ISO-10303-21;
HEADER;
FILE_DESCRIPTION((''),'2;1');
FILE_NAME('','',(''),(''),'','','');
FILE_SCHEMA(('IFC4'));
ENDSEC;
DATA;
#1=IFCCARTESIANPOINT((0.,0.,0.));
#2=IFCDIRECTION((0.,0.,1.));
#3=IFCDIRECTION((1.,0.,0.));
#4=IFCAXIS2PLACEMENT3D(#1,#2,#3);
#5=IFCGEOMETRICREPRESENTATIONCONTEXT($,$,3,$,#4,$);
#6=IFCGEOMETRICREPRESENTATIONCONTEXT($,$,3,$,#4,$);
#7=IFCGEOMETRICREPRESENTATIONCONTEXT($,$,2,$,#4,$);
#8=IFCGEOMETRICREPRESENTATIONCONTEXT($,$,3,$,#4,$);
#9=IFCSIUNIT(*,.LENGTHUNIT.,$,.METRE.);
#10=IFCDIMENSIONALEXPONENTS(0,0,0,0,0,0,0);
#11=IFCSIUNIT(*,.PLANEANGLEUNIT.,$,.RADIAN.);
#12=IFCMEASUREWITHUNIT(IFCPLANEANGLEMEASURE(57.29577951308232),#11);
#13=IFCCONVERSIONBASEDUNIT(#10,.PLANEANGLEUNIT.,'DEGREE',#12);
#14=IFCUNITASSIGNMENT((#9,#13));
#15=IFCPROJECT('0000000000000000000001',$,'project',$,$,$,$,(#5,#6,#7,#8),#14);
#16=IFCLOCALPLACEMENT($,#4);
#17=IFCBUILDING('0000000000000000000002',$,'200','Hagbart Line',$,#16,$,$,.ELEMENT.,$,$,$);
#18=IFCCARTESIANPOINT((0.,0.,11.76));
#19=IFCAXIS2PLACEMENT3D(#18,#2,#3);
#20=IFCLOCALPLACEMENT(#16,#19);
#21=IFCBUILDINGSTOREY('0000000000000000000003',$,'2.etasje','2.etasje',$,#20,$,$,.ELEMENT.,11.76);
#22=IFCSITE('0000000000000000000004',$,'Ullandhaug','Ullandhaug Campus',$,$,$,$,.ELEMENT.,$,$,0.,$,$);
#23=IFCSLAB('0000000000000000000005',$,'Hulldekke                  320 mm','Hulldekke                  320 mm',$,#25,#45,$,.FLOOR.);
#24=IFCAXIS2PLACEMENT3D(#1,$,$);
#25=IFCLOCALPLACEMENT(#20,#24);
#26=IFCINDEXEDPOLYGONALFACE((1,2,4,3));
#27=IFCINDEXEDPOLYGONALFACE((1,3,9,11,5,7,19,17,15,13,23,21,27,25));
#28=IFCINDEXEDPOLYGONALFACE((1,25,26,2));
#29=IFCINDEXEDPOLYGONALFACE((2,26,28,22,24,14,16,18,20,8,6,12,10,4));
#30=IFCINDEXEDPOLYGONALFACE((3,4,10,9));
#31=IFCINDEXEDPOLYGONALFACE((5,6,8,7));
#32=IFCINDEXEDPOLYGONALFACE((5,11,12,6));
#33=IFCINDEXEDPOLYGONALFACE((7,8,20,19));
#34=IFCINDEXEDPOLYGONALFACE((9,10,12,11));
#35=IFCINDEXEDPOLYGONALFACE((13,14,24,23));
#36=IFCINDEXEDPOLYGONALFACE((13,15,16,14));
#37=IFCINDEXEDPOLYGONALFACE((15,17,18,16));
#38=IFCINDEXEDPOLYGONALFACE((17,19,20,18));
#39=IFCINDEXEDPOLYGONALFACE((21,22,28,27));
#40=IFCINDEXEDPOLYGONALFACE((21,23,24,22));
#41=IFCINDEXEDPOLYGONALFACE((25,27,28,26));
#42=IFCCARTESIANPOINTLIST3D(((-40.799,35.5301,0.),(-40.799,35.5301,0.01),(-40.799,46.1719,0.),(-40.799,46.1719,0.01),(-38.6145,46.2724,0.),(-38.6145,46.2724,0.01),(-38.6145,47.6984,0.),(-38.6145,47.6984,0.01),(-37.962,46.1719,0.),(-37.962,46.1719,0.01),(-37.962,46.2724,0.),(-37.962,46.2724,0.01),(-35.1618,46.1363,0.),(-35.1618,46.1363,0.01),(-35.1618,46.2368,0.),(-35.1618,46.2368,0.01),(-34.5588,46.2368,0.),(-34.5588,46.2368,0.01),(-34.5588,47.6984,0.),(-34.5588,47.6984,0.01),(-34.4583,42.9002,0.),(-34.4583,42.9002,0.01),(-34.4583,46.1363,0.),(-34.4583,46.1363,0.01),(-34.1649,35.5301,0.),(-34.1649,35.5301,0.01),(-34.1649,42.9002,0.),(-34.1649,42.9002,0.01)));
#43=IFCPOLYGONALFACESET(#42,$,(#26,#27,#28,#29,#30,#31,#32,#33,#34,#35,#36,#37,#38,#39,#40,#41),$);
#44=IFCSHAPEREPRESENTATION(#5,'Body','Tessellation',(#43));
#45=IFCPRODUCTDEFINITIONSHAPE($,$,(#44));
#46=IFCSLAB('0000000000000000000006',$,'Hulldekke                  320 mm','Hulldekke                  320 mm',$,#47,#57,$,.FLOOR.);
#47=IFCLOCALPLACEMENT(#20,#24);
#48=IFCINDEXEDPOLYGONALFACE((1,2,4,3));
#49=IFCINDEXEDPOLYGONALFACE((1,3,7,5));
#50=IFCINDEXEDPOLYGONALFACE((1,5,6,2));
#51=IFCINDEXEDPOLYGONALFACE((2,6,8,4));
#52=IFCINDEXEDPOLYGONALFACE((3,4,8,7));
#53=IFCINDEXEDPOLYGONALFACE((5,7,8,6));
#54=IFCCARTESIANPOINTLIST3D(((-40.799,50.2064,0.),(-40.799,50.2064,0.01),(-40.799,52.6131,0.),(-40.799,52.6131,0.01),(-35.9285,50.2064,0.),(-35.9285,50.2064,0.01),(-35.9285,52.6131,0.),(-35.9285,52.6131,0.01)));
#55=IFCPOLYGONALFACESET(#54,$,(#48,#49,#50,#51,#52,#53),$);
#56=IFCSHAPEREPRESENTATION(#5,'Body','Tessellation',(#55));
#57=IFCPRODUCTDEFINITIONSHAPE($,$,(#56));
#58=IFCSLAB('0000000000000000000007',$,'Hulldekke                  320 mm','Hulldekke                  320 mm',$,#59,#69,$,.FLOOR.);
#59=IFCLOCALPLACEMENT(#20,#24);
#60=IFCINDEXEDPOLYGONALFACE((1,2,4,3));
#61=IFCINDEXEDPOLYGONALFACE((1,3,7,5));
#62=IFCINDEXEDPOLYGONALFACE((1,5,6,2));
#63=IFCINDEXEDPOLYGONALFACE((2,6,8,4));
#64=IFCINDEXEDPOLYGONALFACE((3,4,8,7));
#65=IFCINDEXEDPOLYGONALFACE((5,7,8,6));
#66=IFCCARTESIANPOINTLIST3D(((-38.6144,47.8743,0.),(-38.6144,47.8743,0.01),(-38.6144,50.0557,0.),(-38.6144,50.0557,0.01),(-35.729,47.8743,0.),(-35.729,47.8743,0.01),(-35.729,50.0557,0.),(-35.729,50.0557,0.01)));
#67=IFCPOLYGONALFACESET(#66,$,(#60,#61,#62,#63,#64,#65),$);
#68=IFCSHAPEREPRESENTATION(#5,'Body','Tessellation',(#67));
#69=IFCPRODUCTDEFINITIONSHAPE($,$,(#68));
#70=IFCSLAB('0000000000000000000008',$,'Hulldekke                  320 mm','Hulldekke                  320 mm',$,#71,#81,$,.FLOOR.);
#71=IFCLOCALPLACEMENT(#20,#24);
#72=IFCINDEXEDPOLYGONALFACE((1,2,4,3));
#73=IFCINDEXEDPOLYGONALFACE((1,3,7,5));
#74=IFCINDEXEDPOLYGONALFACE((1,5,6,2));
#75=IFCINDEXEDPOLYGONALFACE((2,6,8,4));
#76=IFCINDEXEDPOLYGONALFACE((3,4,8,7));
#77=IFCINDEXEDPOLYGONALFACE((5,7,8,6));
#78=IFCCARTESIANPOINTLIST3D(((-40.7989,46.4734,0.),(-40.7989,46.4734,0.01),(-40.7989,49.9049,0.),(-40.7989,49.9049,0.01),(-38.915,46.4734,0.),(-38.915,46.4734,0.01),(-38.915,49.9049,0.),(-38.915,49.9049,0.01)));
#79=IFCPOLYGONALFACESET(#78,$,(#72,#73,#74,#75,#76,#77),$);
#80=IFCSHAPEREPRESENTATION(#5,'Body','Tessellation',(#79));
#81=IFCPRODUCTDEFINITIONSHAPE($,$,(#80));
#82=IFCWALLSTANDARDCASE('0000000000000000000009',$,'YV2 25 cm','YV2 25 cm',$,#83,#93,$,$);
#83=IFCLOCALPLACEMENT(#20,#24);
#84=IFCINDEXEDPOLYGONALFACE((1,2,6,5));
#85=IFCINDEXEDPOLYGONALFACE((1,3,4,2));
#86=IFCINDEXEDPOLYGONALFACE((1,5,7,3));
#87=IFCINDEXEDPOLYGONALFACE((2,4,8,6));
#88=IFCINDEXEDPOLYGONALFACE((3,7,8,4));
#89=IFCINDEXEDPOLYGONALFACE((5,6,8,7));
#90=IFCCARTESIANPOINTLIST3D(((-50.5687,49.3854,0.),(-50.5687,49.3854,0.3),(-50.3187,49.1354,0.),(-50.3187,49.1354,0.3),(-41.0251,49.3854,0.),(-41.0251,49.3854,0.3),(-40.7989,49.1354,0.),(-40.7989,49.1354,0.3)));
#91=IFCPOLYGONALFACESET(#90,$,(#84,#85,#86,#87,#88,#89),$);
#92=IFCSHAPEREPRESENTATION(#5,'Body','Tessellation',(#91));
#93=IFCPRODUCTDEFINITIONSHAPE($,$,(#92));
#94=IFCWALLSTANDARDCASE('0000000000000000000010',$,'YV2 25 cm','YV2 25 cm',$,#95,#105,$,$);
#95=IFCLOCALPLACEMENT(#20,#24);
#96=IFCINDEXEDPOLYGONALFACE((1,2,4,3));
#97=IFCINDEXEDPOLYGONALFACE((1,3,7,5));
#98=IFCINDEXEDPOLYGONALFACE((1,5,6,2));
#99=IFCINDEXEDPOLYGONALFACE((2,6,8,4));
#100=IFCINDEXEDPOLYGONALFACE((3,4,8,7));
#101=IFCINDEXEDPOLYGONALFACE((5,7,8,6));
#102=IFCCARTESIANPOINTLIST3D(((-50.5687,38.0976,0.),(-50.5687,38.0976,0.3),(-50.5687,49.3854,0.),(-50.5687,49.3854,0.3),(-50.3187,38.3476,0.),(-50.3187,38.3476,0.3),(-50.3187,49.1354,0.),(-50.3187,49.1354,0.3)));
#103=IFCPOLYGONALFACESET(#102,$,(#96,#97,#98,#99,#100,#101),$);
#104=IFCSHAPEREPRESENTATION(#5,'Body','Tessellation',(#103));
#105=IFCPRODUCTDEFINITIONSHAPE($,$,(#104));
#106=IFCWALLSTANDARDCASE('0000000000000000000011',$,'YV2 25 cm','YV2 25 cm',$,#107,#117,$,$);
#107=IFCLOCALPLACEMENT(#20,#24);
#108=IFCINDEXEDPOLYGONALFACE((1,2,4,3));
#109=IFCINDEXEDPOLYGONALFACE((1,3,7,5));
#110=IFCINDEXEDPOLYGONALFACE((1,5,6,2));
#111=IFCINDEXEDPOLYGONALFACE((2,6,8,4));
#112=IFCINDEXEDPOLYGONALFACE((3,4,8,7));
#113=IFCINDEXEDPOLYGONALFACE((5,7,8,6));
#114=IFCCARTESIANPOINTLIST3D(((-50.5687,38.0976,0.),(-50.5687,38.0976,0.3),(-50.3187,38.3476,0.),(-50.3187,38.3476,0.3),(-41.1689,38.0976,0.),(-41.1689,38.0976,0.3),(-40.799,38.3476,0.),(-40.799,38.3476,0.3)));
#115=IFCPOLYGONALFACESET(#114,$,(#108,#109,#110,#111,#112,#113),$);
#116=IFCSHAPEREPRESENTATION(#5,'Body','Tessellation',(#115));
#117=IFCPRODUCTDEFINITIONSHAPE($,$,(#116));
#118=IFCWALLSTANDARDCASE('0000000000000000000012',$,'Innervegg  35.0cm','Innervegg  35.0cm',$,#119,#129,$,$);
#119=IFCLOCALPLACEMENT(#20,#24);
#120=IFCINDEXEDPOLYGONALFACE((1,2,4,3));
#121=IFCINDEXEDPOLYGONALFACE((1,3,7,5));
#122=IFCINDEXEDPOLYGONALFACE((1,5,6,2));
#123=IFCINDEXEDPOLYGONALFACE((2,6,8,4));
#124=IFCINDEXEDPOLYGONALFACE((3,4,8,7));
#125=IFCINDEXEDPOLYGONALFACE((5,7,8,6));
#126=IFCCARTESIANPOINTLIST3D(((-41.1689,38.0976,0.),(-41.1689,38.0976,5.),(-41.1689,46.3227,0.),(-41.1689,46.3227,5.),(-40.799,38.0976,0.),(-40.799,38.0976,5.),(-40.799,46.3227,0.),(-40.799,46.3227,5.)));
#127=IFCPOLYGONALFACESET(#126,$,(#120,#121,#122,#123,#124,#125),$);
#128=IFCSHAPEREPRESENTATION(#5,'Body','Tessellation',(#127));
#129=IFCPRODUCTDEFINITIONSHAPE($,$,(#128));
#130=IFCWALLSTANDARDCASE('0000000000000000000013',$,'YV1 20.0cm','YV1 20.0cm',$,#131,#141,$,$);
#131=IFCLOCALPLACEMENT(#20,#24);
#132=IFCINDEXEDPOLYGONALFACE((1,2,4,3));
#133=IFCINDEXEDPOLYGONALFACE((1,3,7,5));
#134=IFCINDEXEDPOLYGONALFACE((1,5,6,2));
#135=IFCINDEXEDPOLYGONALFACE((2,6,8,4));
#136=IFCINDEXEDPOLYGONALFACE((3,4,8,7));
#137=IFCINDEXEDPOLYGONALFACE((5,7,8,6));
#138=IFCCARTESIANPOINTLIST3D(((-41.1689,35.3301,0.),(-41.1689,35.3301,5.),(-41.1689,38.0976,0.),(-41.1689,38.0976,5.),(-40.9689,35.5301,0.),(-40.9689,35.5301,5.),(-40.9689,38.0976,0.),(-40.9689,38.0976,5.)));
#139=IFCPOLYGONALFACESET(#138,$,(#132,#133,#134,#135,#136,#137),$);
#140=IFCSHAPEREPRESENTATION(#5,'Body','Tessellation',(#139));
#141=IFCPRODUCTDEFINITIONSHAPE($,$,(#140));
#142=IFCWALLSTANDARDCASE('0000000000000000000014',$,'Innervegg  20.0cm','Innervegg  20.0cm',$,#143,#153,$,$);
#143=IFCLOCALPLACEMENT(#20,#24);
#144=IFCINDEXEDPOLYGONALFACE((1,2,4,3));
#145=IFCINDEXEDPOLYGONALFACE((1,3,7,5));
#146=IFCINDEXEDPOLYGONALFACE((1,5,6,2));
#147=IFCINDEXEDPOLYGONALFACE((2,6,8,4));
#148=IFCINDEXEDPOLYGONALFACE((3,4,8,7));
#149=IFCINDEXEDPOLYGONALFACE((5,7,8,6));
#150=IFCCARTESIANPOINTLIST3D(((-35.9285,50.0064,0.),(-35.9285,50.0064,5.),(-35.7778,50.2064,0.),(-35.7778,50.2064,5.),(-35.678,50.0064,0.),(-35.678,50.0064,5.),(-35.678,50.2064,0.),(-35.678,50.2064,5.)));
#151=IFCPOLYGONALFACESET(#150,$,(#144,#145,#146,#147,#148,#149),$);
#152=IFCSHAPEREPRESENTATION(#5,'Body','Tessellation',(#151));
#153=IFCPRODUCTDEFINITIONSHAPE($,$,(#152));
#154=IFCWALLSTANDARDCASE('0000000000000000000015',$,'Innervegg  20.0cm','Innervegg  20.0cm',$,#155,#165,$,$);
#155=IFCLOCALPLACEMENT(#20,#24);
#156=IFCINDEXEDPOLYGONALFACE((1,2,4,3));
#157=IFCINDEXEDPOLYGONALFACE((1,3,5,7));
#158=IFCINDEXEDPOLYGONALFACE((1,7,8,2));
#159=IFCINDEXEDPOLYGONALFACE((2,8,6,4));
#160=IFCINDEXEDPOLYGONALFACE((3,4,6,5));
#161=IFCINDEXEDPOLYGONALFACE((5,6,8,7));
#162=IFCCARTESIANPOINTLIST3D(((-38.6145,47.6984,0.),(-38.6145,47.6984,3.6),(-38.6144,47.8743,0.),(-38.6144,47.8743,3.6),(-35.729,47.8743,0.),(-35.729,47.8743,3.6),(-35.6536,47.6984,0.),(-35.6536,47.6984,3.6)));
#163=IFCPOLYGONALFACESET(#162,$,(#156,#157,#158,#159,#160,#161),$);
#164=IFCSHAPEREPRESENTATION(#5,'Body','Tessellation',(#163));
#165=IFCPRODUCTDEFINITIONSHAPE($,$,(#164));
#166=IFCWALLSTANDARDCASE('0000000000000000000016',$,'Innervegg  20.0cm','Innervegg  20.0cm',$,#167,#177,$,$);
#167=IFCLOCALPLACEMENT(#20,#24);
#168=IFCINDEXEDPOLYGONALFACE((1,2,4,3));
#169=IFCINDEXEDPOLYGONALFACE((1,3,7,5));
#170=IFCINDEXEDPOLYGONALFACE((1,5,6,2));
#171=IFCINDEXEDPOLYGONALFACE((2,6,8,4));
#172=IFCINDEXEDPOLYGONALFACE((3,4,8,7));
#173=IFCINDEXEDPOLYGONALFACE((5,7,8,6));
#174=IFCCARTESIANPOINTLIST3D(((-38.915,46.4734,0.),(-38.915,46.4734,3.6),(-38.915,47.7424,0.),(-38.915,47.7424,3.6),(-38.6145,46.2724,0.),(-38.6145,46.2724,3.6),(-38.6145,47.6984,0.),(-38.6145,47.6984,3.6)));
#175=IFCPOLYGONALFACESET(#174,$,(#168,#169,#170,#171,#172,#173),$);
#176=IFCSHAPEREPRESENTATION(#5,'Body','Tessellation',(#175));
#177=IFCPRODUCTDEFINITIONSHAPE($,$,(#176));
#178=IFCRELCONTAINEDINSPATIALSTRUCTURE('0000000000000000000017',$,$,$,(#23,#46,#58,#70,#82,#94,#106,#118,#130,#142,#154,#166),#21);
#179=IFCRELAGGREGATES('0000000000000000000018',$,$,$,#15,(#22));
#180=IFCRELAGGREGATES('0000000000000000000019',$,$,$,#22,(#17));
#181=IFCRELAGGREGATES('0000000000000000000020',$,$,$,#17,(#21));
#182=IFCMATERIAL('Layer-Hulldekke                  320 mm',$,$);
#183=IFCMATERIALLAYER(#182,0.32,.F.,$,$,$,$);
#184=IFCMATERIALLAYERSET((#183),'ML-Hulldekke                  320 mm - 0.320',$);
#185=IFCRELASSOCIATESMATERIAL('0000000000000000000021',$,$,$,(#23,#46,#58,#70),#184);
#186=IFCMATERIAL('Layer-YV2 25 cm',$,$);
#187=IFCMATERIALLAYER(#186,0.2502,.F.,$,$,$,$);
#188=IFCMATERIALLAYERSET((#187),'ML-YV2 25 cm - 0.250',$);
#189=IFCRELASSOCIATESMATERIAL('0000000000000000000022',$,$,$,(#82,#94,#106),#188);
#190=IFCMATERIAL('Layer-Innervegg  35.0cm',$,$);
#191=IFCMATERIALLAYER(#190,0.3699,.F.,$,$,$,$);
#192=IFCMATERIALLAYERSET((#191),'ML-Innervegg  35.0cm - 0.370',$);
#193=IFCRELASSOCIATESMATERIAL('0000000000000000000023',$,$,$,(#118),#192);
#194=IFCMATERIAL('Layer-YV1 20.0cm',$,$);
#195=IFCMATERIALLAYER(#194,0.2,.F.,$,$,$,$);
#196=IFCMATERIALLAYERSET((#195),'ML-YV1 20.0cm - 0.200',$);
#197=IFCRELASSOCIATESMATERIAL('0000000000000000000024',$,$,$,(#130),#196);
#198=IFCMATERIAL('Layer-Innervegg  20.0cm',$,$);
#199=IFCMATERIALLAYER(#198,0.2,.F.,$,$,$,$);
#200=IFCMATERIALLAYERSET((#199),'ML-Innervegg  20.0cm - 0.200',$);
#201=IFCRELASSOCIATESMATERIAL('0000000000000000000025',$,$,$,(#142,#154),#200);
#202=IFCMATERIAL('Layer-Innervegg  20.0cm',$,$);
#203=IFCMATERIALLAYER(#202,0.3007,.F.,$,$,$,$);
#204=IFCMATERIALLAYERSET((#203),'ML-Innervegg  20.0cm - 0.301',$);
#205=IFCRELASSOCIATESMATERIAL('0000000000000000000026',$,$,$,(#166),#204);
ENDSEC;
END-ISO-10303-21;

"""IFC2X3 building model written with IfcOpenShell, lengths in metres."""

from ifc_helpers import new_model, entity, si_unit, converted_unit, frame, origin_with_axes, place, context, project, spatial, polyline, outline, extrude, material, layer, layer_set, layer_usage, element, save


model = new_model("IFC2X3")

# Units and contexts
context_of_model_1 = context(None, 3, world=origin_with_axes())
context_of_model_2 = context(None, 3, world=origin_with_axes())
context_of_model_3 = context(None, 2, world=origin_with_axes())
context_of_model_4 = context(None, 3, world=origin_with_axes())
ifc_project = project(units=[si_unit("LENGTHUNIT", "METRE"), converted_unit("PLANEANGLEUNIT", "DEGREE", entity("IfcPlaneAngleMeasure", 57.29577951308232), si_unit("PLANEANGLEUNIT", "RADIAN"), dimensions=[0, 0, 0, 0, 0, 0, 0])], contexts=[context_of_model_1, context_of_model_2, context_of_model_3, context_of_model_4])

# Site, building, storey
site = spatial("IfcSite", under=ifc_project, Name="Ullandhaug", Description="Ullandhaug Campus", CompositionType="ELEMENT", RefElevation=0.0)
building_placement = place(None, origin_with_axes())
building = spatial("IfcBuilding", under=site, at=building_placement, Name="200", Description="Hagbart Line", CompositionType="ELEMENT")
storey_placement = place(building_placement, frame((0.0, 0.0, 11.76), z_axis=(0.0, 0.0, 1.0), x_axis=(1.0, 0.0, 0.0)))
storey = spatial("IfcBuildingStorey", under=building, at=storey_placement, Name="2.etasje", Description="2.etasje", CompositionType="ELEMENT", Elevation=11.76)

# Slabs
ifc_material_1 = material(Name="Layer-Hulldekke                  320 mm")
ifc_layer_1 = layer(ifc_material_1, 0.32, ventilated=False)
ifc_layer_set_1 = layer_set([ifc_layer_1], Name="ML-Hulldekke                  320 mm - 0.320")
ifc_layer_usage_1 = layer_usage(ifc_layer_set_1, "AXIS2", "POSITIVE", 0.0)
slab_1_placement = place(storey_placement, frame((-40.799, 35.5301, 0.0), z_axis=(0.0, 0.0, 1.0), x_axis=(1.0, 0.0, 0.0)))
element("IfcSlab", 1, at=slab_1_placement, inside=storey, material=ifc_layer_usage_1, Name="Hulldekke                  320 mm", Description="Hulldekke                  320 mm", PredefinedType="FLOOR", context=context_of_model_1, shape_type="SweptSolid", body=[
    extrude(outline(polyline([(0.0, 0.0), (6.6341, 0.0), (6.6341, 7.37), (6.3407, 7.37), (6.3407, 10.6061), (5.6371, 10.6061), (5.6371, 10.7066), (6.2402, 10.7066), (6.2402, 12.1683), (2.1845, 12.1683), (2.1845, 10.7423), (2.837, 10.7423), (2.837, 10.6418), (0.0, 10.6418), (0.0, 0.0)])), origin_with_axes(), (0.0, 0.0, 1.0), 0.01),
])
slab_2_placement = place(storey_placement, frame((-40.799, 50.2064, 0.0), z_axis=(0.0, 0.0, 1.0), x_axis=(1.0, 0.0, 0.0)))
element("IfcSlab", 2, at=slab_2_placement, inside=storey, material=ifc_layer_usage_1, Name="Hulldekke                  320 mm", Description="Hulldekke                  320 mm", PredefinedType="FLOOR", context=context_of_model_1, shape_type="SweptSolid", body=[
    extrude(outline(polyline([(0.0, 0.0), (4.8704, 0.0), (4.8704, 2.4066), (0.0, 2.4066), (0.0, 0.0)])), origin_with_axes(), (0.0, 0.0, 1.0), 0.01),
])
slab_3_placement = place(storey_placement, frame((-38.6144, 47.8743, 0.0), z_axis=(0.0, 0.0, 1.0), x_axis=(1.0, 0.0, 0.0)))
element("IfcSlab", 3, at=slab_3_placement, inside=storey, material=ifc_layer_usage_1, Name="Hulldekke                  320 mm", Description="Hulldekke                  320 mm", PredefinedType="FLOOR", context=context_of_model_1, shape_type="SweptSolid", body=[
    extrude(outline(polyline([(0.0, 0.0), (2.8854, 0.0), (2.8854, 2.1814), (0.0, 2.1814), (0.0, 0.0)])), origin_with_axes(), (0.0, 0.0, 1.0), 0.01),
])
slab_4_placement = place(storey_placement, frame((-40.7989, 46.4734, 0.0), z_axis=(0.0, 0.0, 1.0), x_axis=(1.0, 0.0, 0.0)))
element("IfcSlab", 4, at=slab_4_placement, inside=storey, material=ifc_layer_usage_1, Name="Hulldekke                  320 mm", Description="Hulldekke                  320 mm", PredefinedType="FLOOR", context=context_of_model_1, shape_type="SweptSolid", body=[
    extrude(outline(polyline([(0.0, 0.0), (1.8839, 0.0), (1.8839, 3.4315), (0.0, 3.4315), (0.0, 0.0)])), origin_with_axes(), (0.0, 0.0, 1.0), 0.01),
])

# Walls
ifc_material_2 = material(Name="Layer-YV2 25 cm")
ifc_layer_2 = layer(ifc_material_2, 0.2502, ventilated=False)
ifc_layer_set_2 = layer_set([ifc_layer_2], Name="ML-YV2 25 cm - 0.250")
ifc_layer_usage_2 = layer_usage(ifc_layer_set_2, "AXIS2", "POSITIVE", 0.0)
wall_1_placement = place(storey_placement, frame((-41.0251, 49.3854, 0.0), z_axis=(0.0, 0.0, 1.0), x_axis=(-1.0, 0.0, 0.0)))
element("IfcWallStandardCase", 5, at=wall_1_placement, inside=storey, material=ifc_layer_usage_2, Name="YV2 25 cm", Description="YV2 25 cm", context=context_of_model_1, shape_type="SweptSolid", body=[
    extrude(outline(polyline([(0.0, 0.0), (9.5436, 0.0), (9.2936, 0.25), (-0.2262, 0.25), (0.0, 0.0)])), frame((0.0, 0.0, 0.0), z_axis=(0.0, 0.0, 1.0), x_axis=(1.0, 0.0, 0.0)), (0.0, 0.0, 1.0), 0.3),
])
wall_2_placement = place(storey_placement, frame((-50.5687, 49.3854, 0.0), z_axis=(0.0, 0.0, 1.0), x_axis=(0.0, -1.0, 0.0)))
element("IfcWallStandardCase", 6, at=wall_2_placement, inside=storey, material=ifc_layer_usage_2, Name="YV2 25 cm", Description="YV2 25 cm", context=context_of_model_1, shape_type="SweptSolid", body=[
    extrude(outline(polyline([(0.0, 0.0), (11.2878, 0.0), (11.0378, 0.25), (0.25, 0.25), (0.0, 0.0)])), frame((0.0, 0.0, 0.0), z_axis=(0.0, 0.0, 1.0), x_axis=(1.0, 0.0, 0.0)), (0.0, 0.0, 1.0), 0.3),
])
wall_3_placement = place(storey_placement, frame((-50.5687, 38.0976, 0.0), z_axis=(0.0, 0.0, 1.0), x_axis=(1.0, 0.0, 0.0)))
element("IfcWallStandardCase", 7, at=wall_3_placement, inside=storey, material=ifc_layer_usage_2, Name="YV2 25 cm", Description="YV2 25 cm", context=context_of_model_1, shape_type="SweptSolid", body=[
    extrude(outline(polyline([(0.0, 0.0), (9.3999, 0.0), (9.7698, 0.25), (0.25, 0.25), (0.0, 0.0)])), origin_with_axes(), (0.0, 0.0, 1.0), 0.3),
])
ifc_material_3 = material(Name="Layer-Innervegg  35.0cm")
ifc_layer_3 = layer(ifc_material_3, 0.3699, ventilated=False)
ifc_layer_set_3 = layer_set([ifc_layer_3], Name="ML-Innervegg  35.0cm - 0.370")
ifc_layer_usage_3 = layer_usage(ifc_layer_set_3, "AXIS2", "POSITIVE", 0.0)
wall_4_placement = place(storey_placement, frame((-41.1689, 46.3227, 0.0), z_axis=(0.0, 0.0, 1.0), x_axis=(0.0, -1.0, 0.0)))
element("IfcWallStandardCase", 8, at=wall_4_placement, inside=storey, material=ifc_layer_usage_3, Name="Innervegg  35.0cm", Description="Innervegg  35.0cm", context=context_of_model_1, shape_type="SweptSolid", body=[
    extrude(outline(polyline([(0.0, 0.0), (8.225, 0.0), (8.225, 0.3699), (0.0, 0.3699), (0.0, 0.0)])), frame((0.0, 0.0, 0.0), z_axis=(0.0, 0.0, 1.0), x_axis=(1.0, 0.0, 0.0)), (0.0, 0.0, 1.0), 5.0),
])
ifc_material_4 = material(Name="Layer-YV1 20.0cm")
ifc_layer_4 = layer(ifc_material_4, 0.2, ventilated=False)
ifc_layer_set_4 = layer_set([ifc_layer_4], Name="ML-YV1 20.0cm - 0.200")
ifc_layer_usage_4 = layer_usage(ifc_layer_set_4, "AXIS2", "POSITIVE", 0.0)
wall_5_placement = place(storey_placement, frame((-41.1689, 38.0976, 0.0), z_axis=(0.0, 0.0, 1.0), x_axis=(0.0, -1.0, 0.0)))
element("IfcWallStandardCase", 9, at=wall_5_placement, inside=storey, material=ifc_layer_usage_4, Name="YV1 20.0cm", Description="YV1 20.0cm", context=context_of_model_1, shape_type="SweptSolid", body=[
    extrude(outline(polyline([(0.0, 0.0), (2.7675, 0.0), (2.5675, 0.2), (0.0, 0.2), (0.0, 0.0)])), frame((0.0, 0.0, 0.0), z_axis=(0.0, 0.0, 1.0), x_axis=(1.0, 0.0, 0.0)), (0.0, 0.0, 1.0), 5.0),
])
ifc_material_5 = material(Name="Layer-Innervegg  20.0cm")
ifc_layer_5 = layer(ifc_material_5, 0.2, ventilated=False)
ifc_layer_set_5 = layer_set([ifc_layer_5], Name="ML-Innervegg  20.0cm - 0.200")
ifc_layer_usage_5 = layer_usage(ifc_layer_set_5, "AXIS2", "POSITIVE", 0.0)
wall_6_placement = place(storey_placement, frame((-35.9285, 50.0064, 0.0), z_axis=(0.0, 0.0, 1.0), x_axis=(1.0, 0.0, 0.0)))
element("IfcWallStandardCase", 10, at=wall_6_placement, inside=storey, material=ifc_layer_usage_5, Name="Innervegg  20.0cm", Description="Innervegg  20.0cm", context=context_of_model_1, shape_type="SweptSolid", body=[
    extrude(outline(polyline([(0.0, 0.0), (0.2505, 0.0), (0.2505, 0.2), (0.1507, 0.2), (0.0, 0.0)])), origin_with_axes(), (0.0, 0.0, 1.0), 5.0),
])
wall_7_placement = place(storey_placement, frame((-35.729, 47.8743, 0.0), z_axis=(0.0, 0.0, 1.0), x_axis=(-1.0, 0.0, 0.0)))
element("IfcWallStandardCase", 11, at=wall_7_placement, inside=storey, material=ifc_layer_usage_5, Name="Innervegg  20.0cm", Description="Innervegg  20.0cm", context=context_of_model_1, shape_type="SweptSolid", body=[
    extrude(outline(polyline([(0.0, 0.0), (2.8854, 0.0), (2.8855, 0.1759), (-0.0754, 0.1759), (0.0, 0.0)])), frame((0.0, 0.0, 0.0), z_axis=(0.0, 0.0, 1.0), x_axis=(1.0, 0.0, 0.0)), (0.0, 0.0, 1.0), 3.6),
])
ifc_material_6 = material(Name="Layer-Innervegg  20.0cm")
ifc_layer_6 = layer(ifc_material_6, 0.3007, ventilated=False)
ifc_layer_set_6 = layer_set([ifc_layer_6], Name="ML-Innervegg  20.0cm - 0.301")
ifc_layer_usage_6 = layer_usage(ifc_layer_set_6, "AXIS2", "POSITIVE", 0.0)
wall_8_placement = place(storey_placement, frame((-38.915, 47.7424, 0.0), z_axis=(0.0, 0.0, 1.0), x_axis=(0.0, -1.0, 0.0)))
element("IfcWallStandardCase", 12, at=wall_8_placement, inside=storey, material=ifc_layer_usage_6, Name="Innervegg  20.0cm", Description="Innervegg  20.0cm", context=context_of_model_1, shape_type="SweptSolid", body=[
    extrude(outline(polyline([(0.0, 0.0), (1.269, 0.0), (1.47, 0.3005), (0.044, 0.3005), (0.0, 0.0)])), frame((0.0, 0.0, 0.0), z_axis=(0.0, 0.0, 1.0), x_axis=(1.0, 0.0, 0.0)), (0.0, 0.0, 1.0), 3.6),
])

save(model, "model.ifc")
